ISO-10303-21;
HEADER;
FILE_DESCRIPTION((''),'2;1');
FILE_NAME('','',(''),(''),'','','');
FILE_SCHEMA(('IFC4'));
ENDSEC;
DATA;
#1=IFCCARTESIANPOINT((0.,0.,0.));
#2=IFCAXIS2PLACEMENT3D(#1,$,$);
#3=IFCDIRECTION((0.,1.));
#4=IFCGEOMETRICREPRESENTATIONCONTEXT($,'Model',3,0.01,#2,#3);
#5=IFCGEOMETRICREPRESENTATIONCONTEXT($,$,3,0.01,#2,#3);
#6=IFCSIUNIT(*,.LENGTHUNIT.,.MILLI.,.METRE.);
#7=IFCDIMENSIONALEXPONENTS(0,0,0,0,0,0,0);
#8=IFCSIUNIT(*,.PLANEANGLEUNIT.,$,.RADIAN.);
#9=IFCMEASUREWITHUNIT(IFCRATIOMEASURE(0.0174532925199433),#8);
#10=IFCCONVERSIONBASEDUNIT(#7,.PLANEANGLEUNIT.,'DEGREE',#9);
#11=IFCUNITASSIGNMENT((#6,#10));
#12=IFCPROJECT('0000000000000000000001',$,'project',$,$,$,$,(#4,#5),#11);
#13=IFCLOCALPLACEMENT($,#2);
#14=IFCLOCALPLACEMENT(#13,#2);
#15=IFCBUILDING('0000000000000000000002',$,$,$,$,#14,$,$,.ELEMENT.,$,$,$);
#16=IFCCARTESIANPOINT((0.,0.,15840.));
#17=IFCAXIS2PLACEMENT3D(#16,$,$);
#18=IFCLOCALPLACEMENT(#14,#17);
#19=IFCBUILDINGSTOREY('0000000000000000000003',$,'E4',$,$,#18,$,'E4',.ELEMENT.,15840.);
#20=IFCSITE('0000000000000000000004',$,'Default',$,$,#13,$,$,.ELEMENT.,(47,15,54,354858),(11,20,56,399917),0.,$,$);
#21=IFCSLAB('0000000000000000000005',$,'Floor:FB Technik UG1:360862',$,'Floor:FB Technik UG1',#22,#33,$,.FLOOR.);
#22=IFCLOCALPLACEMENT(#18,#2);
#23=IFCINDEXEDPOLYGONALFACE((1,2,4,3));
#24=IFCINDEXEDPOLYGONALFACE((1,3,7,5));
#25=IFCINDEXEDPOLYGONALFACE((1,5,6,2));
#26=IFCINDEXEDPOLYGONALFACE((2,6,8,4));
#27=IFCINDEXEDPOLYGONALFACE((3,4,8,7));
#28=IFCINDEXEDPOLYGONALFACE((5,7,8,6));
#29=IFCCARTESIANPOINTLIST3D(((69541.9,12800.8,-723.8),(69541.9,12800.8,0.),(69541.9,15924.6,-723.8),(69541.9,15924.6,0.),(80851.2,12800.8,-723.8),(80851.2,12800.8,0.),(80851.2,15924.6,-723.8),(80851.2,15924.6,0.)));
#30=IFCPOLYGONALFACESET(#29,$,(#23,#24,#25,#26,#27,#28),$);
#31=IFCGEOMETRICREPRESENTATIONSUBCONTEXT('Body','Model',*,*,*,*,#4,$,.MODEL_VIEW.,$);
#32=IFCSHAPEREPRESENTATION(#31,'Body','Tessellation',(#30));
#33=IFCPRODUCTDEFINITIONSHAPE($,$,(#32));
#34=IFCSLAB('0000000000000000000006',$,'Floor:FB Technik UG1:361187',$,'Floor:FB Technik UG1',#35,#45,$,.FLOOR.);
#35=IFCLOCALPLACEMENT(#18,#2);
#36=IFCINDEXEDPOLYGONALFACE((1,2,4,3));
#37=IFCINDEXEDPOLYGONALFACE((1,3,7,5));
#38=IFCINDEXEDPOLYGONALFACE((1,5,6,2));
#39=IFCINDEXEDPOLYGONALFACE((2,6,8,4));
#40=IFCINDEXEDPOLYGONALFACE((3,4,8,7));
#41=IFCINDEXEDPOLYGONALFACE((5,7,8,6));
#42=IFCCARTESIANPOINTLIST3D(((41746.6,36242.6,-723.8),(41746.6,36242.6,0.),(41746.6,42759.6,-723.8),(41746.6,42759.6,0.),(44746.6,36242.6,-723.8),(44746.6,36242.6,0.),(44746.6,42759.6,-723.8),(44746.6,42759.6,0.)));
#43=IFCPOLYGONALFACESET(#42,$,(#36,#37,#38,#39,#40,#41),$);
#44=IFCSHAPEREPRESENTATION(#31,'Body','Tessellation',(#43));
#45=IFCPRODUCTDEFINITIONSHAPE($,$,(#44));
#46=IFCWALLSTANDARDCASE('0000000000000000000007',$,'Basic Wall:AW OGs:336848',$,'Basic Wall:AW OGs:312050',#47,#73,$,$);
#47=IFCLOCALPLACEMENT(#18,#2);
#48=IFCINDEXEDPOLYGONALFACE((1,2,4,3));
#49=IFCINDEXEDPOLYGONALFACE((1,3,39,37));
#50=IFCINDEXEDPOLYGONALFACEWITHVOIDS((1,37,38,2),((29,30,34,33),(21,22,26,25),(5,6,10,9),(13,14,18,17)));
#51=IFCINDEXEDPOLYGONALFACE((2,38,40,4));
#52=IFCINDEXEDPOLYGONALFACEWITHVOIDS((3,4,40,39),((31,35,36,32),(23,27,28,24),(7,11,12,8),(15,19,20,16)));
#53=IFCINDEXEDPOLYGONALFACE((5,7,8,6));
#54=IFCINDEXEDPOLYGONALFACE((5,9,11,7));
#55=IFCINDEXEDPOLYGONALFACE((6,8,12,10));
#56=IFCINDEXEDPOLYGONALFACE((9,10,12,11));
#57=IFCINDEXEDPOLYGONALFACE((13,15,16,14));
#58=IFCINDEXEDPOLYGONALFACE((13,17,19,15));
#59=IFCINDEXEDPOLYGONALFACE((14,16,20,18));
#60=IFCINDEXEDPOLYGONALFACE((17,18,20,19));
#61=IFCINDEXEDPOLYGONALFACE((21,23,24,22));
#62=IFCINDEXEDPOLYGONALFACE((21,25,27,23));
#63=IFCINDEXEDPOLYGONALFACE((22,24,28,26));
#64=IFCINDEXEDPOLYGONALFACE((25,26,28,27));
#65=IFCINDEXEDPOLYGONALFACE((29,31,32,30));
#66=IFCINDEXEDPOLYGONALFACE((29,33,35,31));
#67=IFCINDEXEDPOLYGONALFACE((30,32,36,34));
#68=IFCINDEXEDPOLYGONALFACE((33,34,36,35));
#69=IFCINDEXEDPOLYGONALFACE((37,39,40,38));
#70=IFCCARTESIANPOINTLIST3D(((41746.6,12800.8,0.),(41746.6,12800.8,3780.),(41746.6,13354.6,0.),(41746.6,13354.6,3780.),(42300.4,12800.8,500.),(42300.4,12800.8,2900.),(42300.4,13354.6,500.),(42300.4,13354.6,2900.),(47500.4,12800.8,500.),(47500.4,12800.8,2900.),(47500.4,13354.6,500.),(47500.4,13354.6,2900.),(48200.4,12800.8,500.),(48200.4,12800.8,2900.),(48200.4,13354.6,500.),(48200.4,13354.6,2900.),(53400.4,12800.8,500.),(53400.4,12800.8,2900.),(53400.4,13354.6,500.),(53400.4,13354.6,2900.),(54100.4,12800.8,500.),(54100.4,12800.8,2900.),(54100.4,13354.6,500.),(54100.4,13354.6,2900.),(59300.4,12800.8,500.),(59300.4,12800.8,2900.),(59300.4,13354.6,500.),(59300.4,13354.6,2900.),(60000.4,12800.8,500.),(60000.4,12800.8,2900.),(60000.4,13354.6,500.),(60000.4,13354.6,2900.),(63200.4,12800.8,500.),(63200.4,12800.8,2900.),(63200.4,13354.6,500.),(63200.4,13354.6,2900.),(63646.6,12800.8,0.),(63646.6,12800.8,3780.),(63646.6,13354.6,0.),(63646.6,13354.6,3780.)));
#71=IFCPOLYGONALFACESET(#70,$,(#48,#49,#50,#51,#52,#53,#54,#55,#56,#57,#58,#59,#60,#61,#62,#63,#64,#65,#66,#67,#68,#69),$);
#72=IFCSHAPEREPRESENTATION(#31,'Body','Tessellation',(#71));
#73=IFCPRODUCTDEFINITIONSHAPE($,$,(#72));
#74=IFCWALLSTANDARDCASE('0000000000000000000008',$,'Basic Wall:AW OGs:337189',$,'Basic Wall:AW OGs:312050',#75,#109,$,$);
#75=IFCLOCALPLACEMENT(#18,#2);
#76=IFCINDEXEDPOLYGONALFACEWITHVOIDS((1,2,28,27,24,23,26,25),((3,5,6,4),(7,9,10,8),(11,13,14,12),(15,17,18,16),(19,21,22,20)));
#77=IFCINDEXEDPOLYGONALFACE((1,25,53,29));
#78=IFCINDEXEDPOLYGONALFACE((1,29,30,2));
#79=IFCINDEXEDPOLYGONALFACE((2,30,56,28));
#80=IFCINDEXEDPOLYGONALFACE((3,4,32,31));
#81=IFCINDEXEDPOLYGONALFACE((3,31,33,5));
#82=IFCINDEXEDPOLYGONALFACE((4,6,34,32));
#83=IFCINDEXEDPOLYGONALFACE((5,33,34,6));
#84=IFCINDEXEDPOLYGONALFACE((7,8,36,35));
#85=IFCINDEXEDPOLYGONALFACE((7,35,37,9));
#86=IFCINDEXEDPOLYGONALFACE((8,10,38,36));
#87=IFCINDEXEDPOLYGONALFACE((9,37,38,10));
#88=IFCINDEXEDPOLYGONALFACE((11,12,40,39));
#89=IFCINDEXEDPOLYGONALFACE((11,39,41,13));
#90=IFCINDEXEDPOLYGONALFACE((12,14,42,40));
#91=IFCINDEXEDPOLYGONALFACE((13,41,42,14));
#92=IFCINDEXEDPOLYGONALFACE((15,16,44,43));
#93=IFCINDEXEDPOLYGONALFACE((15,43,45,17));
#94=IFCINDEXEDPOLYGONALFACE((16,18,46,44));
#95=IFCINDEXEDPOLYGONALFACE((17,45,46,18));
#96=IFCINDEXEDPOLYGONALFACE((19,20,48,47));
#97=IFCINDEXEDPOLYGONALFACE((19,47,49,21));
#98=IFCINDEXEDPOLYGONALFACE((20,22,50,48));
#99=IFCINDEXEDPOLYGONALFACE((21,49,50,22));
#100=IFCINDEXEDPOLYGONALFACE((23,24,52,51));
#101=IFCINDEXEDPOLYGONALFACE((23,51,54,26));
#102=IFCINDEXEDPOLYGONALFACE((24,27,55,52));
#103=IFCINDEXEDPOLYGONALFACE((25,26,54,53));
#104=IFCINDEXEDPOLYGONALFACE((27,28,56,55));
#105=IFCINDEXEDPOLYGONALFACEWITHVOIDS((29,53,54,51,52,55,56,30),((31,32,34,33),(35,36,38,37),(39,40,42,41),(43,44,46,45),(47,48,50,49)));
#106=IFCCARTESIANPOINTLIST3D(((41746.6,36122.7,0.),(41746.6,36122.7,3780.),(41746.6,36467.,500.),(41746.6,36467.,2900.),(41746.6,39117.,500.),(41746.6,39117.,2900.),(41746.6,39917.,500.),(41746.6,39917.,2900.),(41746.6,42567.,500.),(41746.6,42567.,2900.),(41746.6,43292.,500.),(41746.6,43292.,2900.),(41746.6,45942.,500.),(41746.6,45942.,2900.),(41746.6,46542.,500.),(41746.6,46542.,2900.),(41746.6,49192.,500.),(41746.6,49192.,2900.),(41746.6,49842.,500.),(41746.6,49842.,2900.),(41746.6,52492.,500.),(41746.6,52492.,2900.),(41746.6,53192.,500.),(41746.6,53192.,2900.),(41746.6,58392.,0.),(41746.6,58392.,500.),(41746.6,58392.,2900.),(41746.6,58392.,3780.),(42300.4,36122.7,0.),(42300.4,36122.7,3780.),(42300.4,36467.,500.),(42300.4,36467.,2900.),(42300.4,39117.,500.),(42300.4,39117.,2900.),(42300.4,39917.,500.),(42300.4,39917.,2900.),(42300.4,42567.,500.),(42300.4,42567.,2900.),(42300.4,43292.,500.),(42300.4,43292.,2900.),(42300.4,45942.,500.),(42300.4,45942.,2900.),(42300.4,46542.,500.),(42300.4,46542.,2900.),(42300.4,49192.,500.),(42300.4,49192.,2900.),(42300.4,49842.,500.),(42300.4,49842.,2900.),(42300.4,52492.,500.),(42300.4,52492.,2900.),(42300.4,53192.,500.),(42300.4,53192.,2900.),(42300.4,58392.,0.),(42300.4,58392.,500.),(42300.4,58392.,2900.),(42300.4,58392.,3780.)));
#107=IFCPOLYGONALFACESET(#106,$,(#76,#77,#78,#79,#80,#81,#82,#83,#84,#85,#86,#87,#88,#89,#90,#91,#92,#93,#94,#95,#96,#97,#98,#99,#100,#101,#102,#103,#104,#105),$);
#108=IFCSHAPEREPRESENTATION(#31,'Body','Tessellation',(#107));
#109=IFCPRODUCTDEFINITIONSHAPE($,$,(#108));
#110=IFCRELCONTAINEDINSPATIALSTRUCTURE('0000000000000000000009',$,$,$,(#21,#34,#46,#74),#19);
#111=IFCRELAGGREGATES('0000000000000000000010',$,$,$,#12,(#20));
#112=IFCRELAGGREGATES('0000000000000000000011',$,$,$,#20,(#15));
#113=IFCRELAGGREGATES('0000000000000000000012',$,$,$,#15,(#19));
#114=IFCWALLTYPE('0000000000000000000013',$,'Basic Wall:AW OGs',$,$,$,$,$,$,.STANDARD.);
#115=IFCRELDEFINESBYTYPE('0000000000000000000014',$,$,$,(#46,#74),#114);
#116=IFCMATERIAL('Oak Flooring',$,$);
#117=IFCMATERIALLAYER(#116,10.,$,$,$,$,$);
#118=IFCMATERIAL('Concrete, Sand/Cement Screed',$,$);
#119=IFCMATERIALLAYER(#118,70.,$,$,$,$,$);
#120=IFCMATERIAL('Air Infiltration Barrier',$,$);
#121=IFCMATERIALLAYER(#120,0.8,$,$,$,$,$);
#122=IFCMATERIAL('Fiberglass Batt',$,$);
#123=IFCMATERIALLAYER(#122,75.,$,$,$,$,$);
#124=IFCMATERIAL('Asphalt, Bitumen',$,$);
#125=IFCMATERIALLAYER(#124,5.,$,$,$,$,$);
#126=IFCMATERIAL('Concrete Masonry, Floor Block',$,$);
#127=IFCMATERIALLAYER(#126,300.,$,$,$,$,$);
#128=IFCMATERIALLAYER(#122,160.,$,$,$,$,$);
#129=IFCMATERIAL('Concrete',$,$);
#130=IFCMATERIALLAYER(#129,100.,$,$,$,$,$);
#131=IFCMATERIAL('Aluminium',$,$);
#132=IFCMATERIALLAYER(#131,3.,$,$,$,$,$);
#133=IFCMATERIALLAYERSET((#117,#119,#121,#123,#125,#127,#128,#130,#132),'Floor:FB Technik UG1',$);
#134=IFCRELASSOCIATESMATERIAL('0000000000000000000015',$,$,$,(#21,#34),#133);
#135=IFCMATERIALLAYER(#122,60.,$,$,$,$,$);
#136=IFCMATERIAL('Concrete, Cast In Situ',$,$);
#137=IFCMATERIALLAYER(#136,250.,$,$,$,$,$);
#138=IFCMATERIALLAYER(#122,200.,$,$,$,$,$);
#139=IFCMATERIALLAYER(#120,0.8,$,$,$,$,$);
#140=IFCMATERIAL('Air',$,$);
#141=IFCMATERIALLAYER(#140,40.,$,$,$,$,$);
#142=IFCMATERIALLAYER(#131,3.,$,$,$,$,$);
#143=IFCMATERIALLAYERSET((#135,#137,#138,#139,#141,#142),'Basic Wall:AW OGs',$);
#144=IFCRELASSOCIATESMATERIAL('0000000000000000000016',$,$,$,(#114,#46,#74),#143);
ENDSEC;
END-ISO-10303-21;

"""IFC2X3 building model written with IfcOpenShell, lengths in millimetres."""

from ifc_helpers import new_model, entity, si_unit, converted_unit, direction, frame, frame_2d, origin, place, context, subcontext, project, spatial, rectangle, extrude, material, layer, layer_set, layer_usage, type_object, element, save


model = new_model("IFC2X3")

# Units and contexts
model_context = context("Model", 3, precision=0.01, world=origin(), true_north=direction((0.0, 1.0)))
context_of_model = context(None, 3, precision=0.01, world=origin(), true_north=direction((0.0, 1.0)))
body_context = subcontext(model_context, "Body", "Model", "MODEL_VIEW")
ifc_project = project(units=[si_unit("LENGTHUNIT", "METRE", prefix="MILLI"), converted_unit("PLANEANGLEUNIT", "DEGREE", entity("IfcRatioMeasure", 0.0174532925199433), si_unit("PLANEANGLEUNIT", "RADIAN"), dimensions=[0, 0, 0, 0, 0, 0, 0])], contexts=[model_context, context_of_model])

# Site, building, storey
site_placement = place(None, origin())
site = spatial("IfcSite", under=ifc_project, at=site_placement, Name="Default", CompositionType="ELEMENT", RefLatitude=(47, 15, 54, 354858), RefLongitude=(11, 20, 56, 399917), RefElevation=0.0)
building_placement = place(site_placement, origin())
building = spatial("IfcBuilding", under=site, at=building_placement, CompositionType="ELEMENT")
storey_placement = place(building_placement, frame((0.0, 0.0, 15840.0)))
storey = spatial("IfcBuildingStorey", under=building, at=storey_placement, Name="E4", LongName="E4", CompositionType="ELEMENT", Elevation=15840.0)

# Shared definitions
ifc_material_1 = material(Name="Oak Flooring")
ifc_material_2 = material(Name="Concrete, Sand/Cement Screed")
ifc_material_3 = material(Name="Air Infiltration Barrier")
ifc_material_4 = material(Name="Fiberglass Batt")
ifc_material_5 = material(Name="Concrete")

# Slabs
ifc_layer_1 = layer(ifc_material_1, 10.0)
ifc_layer_2 = layer(ifc_material_2, 70.0)
ifc_layer_3 = layer(ifc_material_3, 0.8)
ifc_layer_4 = layer(ifc_material_4, 75.0)
ifc_material_6 = material(Name="Asphalt, Bitumen")
ifc_layer_5 = layer(ifc_material_6, 5.0)
ifc_material_7 = material(Name="Concrete Masonry, Floor Block")
ifc_layer_6 = layer(ifc_material_7, 300.0)
ifc_layer_7 = layer(ifc_material_4, 160.0)
ifc_layer_8 = layer(ifc_material_5, 100.0)
ifc_material_8 = material(Name="Aluminium")
ifc_layer_9 = layer(ifc_material_8, 3.0)
ifc_layer_set_1 = layer_set([ifc_layer_1, ifc_layer_2, ifc_layer_3, ifc_layer_4, ifc_layer_5, ifc_layer_6, ifc_layer_7, ifc_layer_8, ifc_layer_9], Name="Floor:FB Technik UG1")
ifc_layer_usage_1 = layer_usage(ifc_layer_set_1, "AXIS3", "POSITIVE", 0.0)
slab_1_placement = place(storey_placement, origin())
element("IfcSlab", 1, at=slab_1_placement, inside=storey, material=ifc_layer_usage_1, Name="Floor:FB Technik UG1:360862", ObjectType="Floor:FB Technik UG1", PredefinedType="FLOOR", context=body_context, shape_type="SweptSolid", body=[
    extrude(rectangle(XDim=3123.8, YDim=11309.3, at=frame_2d((0.0, 0.0), x_axis=(1.0, 0.0))), frame((75196.5, 14362.7, 0.0), z_axis=(0.0, 0.0, -1.0), x_axis=(0.0, 1.0, 0.0)), (0.0, 0.0, 1.0), 723.8),
])
ifc_layer_usage_2 = layer_usage(ifc_layer_set_1, "AXIS3", "POSITIVE", 0.0)
slab_2_placement = place(storey_placement, origin())
element("IfcSlab", 2, at=slab_2_placement, inside=storey, material=ifc_layer_usage_2, Name="Floor:FB Technik UG1:361187", ObjectType="Floor:FB Technik UG1", PredefinedType="FLOOR", context=body_context, shape_type="SweptSolid", body=[
    extrude(rectangle(XDim=6517.1, YDim=3000.0, at=frame_2d((0.0, 0.0), x_axis=(1.0, 0.0))), frame((43246.6, 39501.1, 0.0), z_axis=(0.0, 0.0, -1.0), x_axis=(0.0, 1.0, 0.0)), (0.0, 0.0, 1.0), 723.8),
])

# Walls, openings
ifc_layer_10 = layer(ifc_material_4, 60.0)
ifc_material_9 = material(Name="Concrete, Cast In Situ")
ifc_layer_11 = layer(ifc_material_9, 250.0)
ifc_layer_12 = layer(ifc_material_4, 200.0)
ifc_layer_13 = layer(ifc_material_3, 0.8)
ifc_material_10 = material(Name="Air")
ifc_layer_14 = layer(ifc_material_10, 40.0)
ifc_layer_15 = layer(ifc_material_8, 3.0)
ifc_layer_set_2 = layer_set([ifc_layer_10, ifc_layer_11, ifc_layer_12, ifc_layer_13, ifc_layer_14, ifc_layer_15], Name="Basic Wall:AW OGs")
ifc_layer_usage_3 = layer_usage(ifc_layer_set_2, "AXIS2", "NEGATIVE", 276.9)
wall_type = type_object("IfcWallType", Name="Basic Wall:AW OGs", PredefinedType="STANDARD", material=ifc_layer_set_2)
wall_1_placement = place(storey_placement, frame((41746.6, 13077.7, 0.0)))
wall_1 = element("IfcWallStandardCase", 3, at=wall_1_placement, inside=storey, type_object=wall_type, material=ifc_layer_usage_3, Name="Basic Wall:AW OGs:336848", ObjectType="Basic Wall:AW OGs:312050", context=body_context, shape_type="SweptSolid", body=[
    extrude(rectangle(XDim=21900.0, YDim=553.8, at=frame_2d((10950.0, 0.0), x_axis=(-1.0, 0.0))), origin(), (0.0, 0.0, 1.0), 3780.0),
])
opening_1_placement = place(wall_1_placement, origin())
element("IfcOpeningElement", 4, at=opening_1_placement, cuts=wall_1, ObjectType="Opening", context=body_context, shape_type="SweptSolid", body=[
    extrude(rectangle(XDim=2400.0, YDim=5200.0, at=frame_2d((0.0, 0.0), x_axis=(1.0, 0.0))), frame((24500.0, -1247.1, 1700.0), z_axis=(0.0, 1.0, 0.0), x_axis=(0.0, 0.0, -1.0)), (0.0, 0.0, 1.0), 3048.0),
])
opening_2_placement = place(wall_1_placement, origin())
element("IfcOpeningElement", 5, at=opening_2_placement, cuts=wall_1, ObjectType="Opening", context=body_context, shape_type="SweptSolid", body=[
    extrude(rectangle(XDim=2400.0, YDim=553.8, at=frame_2d((0.0, 0.0), x_axis=(0.0, 1.0))), frame((276.9, 276.9, 1700.0), z_axis=(0.0, 1.0, 0.0), x_axis=(-1.0, 0.0, 0.0)), (0.0, 0.0, 1.0), 2650.0),
])
opening_3_placement = place(wall_1_placement, frame((21453.8, 276.9, 500.0)))
element("IfcOpeningElement", 6, at=opening_3_placement, cuts=wall_1, ObjectType="Opening", context=body_context, shape_type="SweptSolid", body=[
    extrude(rectangle(XDim=2400.0, YDim=3200.0, at=frame_2d((1200.0, 1600.0), x_axis=(-1.0, 0.0))), frame((0.0, 0.0, 0.0), z_axis=(0.0, -1.0, 0.0), x_axis=(0.0, 0.0, 1.0)), (0.0, 0.0, 1.0), 553.8),
])
opening_4_placement = place(wall_1_placement, frame((5753.8, 276.9, 500.0)))
element("IfcOpeningElement", 7, at=opening_4_placement, cuts=wall_1, ObjectType="Opening", context=body_context, shape_type="SweptSolid", body=[
    extrude(rectangle(XDim=2400.0, YDim=5200.0, at=frame_2d((1200.0, 2600.0), x_axis=(-1.0, 0.0))), frame((0.0, 0.0, 0.0), z_axis=(0.0, -1.0, 0.0), x_axis=(0.0, 0.0, 1.0)), (0.0, 0.0, 1.0), 553.8),
])
opening_5_placement = place(wall_1_placement, frame((17553.8, 276.9, 500.0)))
element("IfcOpeningElement", 8, at=opening_5_placement, cuts=wall_1, ObjectType="Opening", context=body_context, shape_type="SweptSolid", body=[
    extrude(rectangle(XDim=2400.0, YDim=5200.0, at=frame_2d((1200.0, 2600.0), x_axis=(-1.0, 0.0))), frame((0.0, 0.0, 0.0), z_axis=(0.0, -1.0, 0.0), x_axis=(0.0, 0.0, 1.0)), (0.0, 0.0, 1.0), 553.8),
])
opening_6_placement = place(wall_1_placement, frame((11653.8, 276.9, 500.0)))
element("IfcOpeningElement", 9, at=opening_6_placement, cuts=wall_1, ObjectType="Opening", context=body_context, shape_type="SweptSolid", body=[
    extrude(rectangle(XDim=2400.0, YDim=5200.0, at=frame_2d((1200.0, 2600.0), x_axis=(-1.0, 0.0))), frame((0.0, 0.0, 0.0), z_axis=(0.0, -1.0, 0.0), x_axis=(0.0, 0.0, 1.0)), (0.0, 0.0, 1.0), 553.8),
])
ifc_layer_usage_4 = layer_usage(ifc_layer_set_2, "AXIS2", "NEGATIVE", 276.9)
wall_2_placement = place(storey_placement, frame((42023.5, 58392.0, 0.0), z_axis=(0.0, 0.0, 1.0), x_axis=(0.0, -1.0, 0.0)))
wall_2 = element("IfcWallStandardCase", 10, at=wall_2_placement, inside=storey, type_object=wall_type, material=ifc_layer_usage_4, Name="Basic Wall:AW OGs:337189", ObjectType="Basic Wall:AW OGs:312050", context=body_context, shape_type="SweptSolid", body=[
    extrude(rectangle(XDim=22269.3, YDim=553.8, at=frame_2d((11134.7, 0.0), x_axis=(-1.0, 0.0))), origin(), (0.0, 0.0, 1.0), 3780.0),
])
opening_7_placement = place(wall_2_placement, frame((5200.0, 276.9, 500.0)))
element("IfcOpeningElement", 11, at=opening_7_placement, cuts=wall_2, ObjectType="Opening", context=body_context, shape_type="SweptSolid", body=[
    extrude(rectangle(XDim=2400.0, YDim=5200.0, at=frame_2d((1200.0, 2600.0), x_axis=(-1.0, 0.0))), frame((0.0, 0.0, 0.0), z_axis=(0.0, -1.0, 0.0), x_axis=(0.0, 0.0, 1.0)), (0.0, 0.0, 1.0), 553.8),
])
opening_8_placement = place(wall_2_placement, frame((15100.0, 276.9, 500.0)))
element("IfcOpeningElement", 12, at=opening_8_placement, cuts=wall_2, ObjectType="Opening", context=body_context, shape_type="SweptSolid", body=[
    extrude(rectangle(XDim=2400.0, YDim=2650.0, at=frame_2d((1200.0, 1325.0), x_axis=(-1.0, 0.0))), frame((0.0, 0.0, 0.0), z_axis=(0.0, -1.0, 0.0), x_axis=(0.0, 0.0, 1.0)), (0.0, 0.0, 1.0), 553.8),
])
opening_9_placement = place(wall_2_placement, frame((11850.0, 276.9, 500.0)))
element("IfcOpeningElement", 13, at=opening_9_placement, cuts=wall_2, ObjectType="Opening", context=body_context, shape_type="SweptSolid", body=[
    extrude(rectangle(XDim=2400.0, YDim=2650.0, at=frame_2d((1200.0, 1325.0), x_axis=(-1.0, 0.0))), frame((0.0, 0.0, 0.0), z_axis=(0.0, -1.0, 0.0), x_axis=(0.0, 0.0, 1.0)), (0.0, 0.0, 1.0), 553.8),
])
opening_10_placement = place(wall_2_placement, frame((8550.0, 276.9, 500.0)))
element("IfcOpeningElement", 14, at=opening_10_placement, cuts=wall_2, ObjectType="Opening", context=body_context, shape_type="SweptSolid", body=[
    extrude(rectangle(XDim=2400.0, YDim=2650.0, at=frame_2d((1200.0, 1325.0), x_axis=(-1.0, 0.0))), frame((0.0, 0.0, 0.0), z_axis=(0.0, -1.0, 0.0), x_axis=(0.0, 0.0, 1.0)), (0.0, 0.0, 1.0), 553.8),
])
opening_11_placement = place(wall_2_placement, frame((21925.0, 276.9, 500.0)))
element("IfcOpeningElement", 15, at=opening_11_placement, cuts=wall_2, ObjectType="Opening", context=body_context, shape_type="SweptSolid", body=[
    extrude(rectangle(XDim=2400.0, YDim=2650.0, at=frame_2d((1200.0, 1325.0), x_axis=(-1.0, 0.0))), frame((0.0, 0.0, 0.0), z_axis=(0.0, -1.0, 0.0), x_axis=(0.0, 0.0, 1.0)), (0.0, 0.0, 1.0), 553.8),
])
opening_12_placement = place(wall_2_placement, frame((18475.0, 276.9, 500.0)))
element("IfcOpeningElement", 16, at=opening_12_placement, cuts=wall_2, ObjectType="Opening", context=body_context, shape_type="SweptSolid", body=[
    extrude(rectangle(XDim=2400.0, YDim=2650.0, at=frame_2d((1200.0, 1325.0), x_axis=(-1.0, 0.0))), frame((0.0, 0.0, 0.0), z_axis=(0.0, -1.0, 0.0), x_axis=(0.0, 0.0, 1.0)), (0.0, 0.0, 1.0), 553.8),
])

save(model, "model.ifc")
